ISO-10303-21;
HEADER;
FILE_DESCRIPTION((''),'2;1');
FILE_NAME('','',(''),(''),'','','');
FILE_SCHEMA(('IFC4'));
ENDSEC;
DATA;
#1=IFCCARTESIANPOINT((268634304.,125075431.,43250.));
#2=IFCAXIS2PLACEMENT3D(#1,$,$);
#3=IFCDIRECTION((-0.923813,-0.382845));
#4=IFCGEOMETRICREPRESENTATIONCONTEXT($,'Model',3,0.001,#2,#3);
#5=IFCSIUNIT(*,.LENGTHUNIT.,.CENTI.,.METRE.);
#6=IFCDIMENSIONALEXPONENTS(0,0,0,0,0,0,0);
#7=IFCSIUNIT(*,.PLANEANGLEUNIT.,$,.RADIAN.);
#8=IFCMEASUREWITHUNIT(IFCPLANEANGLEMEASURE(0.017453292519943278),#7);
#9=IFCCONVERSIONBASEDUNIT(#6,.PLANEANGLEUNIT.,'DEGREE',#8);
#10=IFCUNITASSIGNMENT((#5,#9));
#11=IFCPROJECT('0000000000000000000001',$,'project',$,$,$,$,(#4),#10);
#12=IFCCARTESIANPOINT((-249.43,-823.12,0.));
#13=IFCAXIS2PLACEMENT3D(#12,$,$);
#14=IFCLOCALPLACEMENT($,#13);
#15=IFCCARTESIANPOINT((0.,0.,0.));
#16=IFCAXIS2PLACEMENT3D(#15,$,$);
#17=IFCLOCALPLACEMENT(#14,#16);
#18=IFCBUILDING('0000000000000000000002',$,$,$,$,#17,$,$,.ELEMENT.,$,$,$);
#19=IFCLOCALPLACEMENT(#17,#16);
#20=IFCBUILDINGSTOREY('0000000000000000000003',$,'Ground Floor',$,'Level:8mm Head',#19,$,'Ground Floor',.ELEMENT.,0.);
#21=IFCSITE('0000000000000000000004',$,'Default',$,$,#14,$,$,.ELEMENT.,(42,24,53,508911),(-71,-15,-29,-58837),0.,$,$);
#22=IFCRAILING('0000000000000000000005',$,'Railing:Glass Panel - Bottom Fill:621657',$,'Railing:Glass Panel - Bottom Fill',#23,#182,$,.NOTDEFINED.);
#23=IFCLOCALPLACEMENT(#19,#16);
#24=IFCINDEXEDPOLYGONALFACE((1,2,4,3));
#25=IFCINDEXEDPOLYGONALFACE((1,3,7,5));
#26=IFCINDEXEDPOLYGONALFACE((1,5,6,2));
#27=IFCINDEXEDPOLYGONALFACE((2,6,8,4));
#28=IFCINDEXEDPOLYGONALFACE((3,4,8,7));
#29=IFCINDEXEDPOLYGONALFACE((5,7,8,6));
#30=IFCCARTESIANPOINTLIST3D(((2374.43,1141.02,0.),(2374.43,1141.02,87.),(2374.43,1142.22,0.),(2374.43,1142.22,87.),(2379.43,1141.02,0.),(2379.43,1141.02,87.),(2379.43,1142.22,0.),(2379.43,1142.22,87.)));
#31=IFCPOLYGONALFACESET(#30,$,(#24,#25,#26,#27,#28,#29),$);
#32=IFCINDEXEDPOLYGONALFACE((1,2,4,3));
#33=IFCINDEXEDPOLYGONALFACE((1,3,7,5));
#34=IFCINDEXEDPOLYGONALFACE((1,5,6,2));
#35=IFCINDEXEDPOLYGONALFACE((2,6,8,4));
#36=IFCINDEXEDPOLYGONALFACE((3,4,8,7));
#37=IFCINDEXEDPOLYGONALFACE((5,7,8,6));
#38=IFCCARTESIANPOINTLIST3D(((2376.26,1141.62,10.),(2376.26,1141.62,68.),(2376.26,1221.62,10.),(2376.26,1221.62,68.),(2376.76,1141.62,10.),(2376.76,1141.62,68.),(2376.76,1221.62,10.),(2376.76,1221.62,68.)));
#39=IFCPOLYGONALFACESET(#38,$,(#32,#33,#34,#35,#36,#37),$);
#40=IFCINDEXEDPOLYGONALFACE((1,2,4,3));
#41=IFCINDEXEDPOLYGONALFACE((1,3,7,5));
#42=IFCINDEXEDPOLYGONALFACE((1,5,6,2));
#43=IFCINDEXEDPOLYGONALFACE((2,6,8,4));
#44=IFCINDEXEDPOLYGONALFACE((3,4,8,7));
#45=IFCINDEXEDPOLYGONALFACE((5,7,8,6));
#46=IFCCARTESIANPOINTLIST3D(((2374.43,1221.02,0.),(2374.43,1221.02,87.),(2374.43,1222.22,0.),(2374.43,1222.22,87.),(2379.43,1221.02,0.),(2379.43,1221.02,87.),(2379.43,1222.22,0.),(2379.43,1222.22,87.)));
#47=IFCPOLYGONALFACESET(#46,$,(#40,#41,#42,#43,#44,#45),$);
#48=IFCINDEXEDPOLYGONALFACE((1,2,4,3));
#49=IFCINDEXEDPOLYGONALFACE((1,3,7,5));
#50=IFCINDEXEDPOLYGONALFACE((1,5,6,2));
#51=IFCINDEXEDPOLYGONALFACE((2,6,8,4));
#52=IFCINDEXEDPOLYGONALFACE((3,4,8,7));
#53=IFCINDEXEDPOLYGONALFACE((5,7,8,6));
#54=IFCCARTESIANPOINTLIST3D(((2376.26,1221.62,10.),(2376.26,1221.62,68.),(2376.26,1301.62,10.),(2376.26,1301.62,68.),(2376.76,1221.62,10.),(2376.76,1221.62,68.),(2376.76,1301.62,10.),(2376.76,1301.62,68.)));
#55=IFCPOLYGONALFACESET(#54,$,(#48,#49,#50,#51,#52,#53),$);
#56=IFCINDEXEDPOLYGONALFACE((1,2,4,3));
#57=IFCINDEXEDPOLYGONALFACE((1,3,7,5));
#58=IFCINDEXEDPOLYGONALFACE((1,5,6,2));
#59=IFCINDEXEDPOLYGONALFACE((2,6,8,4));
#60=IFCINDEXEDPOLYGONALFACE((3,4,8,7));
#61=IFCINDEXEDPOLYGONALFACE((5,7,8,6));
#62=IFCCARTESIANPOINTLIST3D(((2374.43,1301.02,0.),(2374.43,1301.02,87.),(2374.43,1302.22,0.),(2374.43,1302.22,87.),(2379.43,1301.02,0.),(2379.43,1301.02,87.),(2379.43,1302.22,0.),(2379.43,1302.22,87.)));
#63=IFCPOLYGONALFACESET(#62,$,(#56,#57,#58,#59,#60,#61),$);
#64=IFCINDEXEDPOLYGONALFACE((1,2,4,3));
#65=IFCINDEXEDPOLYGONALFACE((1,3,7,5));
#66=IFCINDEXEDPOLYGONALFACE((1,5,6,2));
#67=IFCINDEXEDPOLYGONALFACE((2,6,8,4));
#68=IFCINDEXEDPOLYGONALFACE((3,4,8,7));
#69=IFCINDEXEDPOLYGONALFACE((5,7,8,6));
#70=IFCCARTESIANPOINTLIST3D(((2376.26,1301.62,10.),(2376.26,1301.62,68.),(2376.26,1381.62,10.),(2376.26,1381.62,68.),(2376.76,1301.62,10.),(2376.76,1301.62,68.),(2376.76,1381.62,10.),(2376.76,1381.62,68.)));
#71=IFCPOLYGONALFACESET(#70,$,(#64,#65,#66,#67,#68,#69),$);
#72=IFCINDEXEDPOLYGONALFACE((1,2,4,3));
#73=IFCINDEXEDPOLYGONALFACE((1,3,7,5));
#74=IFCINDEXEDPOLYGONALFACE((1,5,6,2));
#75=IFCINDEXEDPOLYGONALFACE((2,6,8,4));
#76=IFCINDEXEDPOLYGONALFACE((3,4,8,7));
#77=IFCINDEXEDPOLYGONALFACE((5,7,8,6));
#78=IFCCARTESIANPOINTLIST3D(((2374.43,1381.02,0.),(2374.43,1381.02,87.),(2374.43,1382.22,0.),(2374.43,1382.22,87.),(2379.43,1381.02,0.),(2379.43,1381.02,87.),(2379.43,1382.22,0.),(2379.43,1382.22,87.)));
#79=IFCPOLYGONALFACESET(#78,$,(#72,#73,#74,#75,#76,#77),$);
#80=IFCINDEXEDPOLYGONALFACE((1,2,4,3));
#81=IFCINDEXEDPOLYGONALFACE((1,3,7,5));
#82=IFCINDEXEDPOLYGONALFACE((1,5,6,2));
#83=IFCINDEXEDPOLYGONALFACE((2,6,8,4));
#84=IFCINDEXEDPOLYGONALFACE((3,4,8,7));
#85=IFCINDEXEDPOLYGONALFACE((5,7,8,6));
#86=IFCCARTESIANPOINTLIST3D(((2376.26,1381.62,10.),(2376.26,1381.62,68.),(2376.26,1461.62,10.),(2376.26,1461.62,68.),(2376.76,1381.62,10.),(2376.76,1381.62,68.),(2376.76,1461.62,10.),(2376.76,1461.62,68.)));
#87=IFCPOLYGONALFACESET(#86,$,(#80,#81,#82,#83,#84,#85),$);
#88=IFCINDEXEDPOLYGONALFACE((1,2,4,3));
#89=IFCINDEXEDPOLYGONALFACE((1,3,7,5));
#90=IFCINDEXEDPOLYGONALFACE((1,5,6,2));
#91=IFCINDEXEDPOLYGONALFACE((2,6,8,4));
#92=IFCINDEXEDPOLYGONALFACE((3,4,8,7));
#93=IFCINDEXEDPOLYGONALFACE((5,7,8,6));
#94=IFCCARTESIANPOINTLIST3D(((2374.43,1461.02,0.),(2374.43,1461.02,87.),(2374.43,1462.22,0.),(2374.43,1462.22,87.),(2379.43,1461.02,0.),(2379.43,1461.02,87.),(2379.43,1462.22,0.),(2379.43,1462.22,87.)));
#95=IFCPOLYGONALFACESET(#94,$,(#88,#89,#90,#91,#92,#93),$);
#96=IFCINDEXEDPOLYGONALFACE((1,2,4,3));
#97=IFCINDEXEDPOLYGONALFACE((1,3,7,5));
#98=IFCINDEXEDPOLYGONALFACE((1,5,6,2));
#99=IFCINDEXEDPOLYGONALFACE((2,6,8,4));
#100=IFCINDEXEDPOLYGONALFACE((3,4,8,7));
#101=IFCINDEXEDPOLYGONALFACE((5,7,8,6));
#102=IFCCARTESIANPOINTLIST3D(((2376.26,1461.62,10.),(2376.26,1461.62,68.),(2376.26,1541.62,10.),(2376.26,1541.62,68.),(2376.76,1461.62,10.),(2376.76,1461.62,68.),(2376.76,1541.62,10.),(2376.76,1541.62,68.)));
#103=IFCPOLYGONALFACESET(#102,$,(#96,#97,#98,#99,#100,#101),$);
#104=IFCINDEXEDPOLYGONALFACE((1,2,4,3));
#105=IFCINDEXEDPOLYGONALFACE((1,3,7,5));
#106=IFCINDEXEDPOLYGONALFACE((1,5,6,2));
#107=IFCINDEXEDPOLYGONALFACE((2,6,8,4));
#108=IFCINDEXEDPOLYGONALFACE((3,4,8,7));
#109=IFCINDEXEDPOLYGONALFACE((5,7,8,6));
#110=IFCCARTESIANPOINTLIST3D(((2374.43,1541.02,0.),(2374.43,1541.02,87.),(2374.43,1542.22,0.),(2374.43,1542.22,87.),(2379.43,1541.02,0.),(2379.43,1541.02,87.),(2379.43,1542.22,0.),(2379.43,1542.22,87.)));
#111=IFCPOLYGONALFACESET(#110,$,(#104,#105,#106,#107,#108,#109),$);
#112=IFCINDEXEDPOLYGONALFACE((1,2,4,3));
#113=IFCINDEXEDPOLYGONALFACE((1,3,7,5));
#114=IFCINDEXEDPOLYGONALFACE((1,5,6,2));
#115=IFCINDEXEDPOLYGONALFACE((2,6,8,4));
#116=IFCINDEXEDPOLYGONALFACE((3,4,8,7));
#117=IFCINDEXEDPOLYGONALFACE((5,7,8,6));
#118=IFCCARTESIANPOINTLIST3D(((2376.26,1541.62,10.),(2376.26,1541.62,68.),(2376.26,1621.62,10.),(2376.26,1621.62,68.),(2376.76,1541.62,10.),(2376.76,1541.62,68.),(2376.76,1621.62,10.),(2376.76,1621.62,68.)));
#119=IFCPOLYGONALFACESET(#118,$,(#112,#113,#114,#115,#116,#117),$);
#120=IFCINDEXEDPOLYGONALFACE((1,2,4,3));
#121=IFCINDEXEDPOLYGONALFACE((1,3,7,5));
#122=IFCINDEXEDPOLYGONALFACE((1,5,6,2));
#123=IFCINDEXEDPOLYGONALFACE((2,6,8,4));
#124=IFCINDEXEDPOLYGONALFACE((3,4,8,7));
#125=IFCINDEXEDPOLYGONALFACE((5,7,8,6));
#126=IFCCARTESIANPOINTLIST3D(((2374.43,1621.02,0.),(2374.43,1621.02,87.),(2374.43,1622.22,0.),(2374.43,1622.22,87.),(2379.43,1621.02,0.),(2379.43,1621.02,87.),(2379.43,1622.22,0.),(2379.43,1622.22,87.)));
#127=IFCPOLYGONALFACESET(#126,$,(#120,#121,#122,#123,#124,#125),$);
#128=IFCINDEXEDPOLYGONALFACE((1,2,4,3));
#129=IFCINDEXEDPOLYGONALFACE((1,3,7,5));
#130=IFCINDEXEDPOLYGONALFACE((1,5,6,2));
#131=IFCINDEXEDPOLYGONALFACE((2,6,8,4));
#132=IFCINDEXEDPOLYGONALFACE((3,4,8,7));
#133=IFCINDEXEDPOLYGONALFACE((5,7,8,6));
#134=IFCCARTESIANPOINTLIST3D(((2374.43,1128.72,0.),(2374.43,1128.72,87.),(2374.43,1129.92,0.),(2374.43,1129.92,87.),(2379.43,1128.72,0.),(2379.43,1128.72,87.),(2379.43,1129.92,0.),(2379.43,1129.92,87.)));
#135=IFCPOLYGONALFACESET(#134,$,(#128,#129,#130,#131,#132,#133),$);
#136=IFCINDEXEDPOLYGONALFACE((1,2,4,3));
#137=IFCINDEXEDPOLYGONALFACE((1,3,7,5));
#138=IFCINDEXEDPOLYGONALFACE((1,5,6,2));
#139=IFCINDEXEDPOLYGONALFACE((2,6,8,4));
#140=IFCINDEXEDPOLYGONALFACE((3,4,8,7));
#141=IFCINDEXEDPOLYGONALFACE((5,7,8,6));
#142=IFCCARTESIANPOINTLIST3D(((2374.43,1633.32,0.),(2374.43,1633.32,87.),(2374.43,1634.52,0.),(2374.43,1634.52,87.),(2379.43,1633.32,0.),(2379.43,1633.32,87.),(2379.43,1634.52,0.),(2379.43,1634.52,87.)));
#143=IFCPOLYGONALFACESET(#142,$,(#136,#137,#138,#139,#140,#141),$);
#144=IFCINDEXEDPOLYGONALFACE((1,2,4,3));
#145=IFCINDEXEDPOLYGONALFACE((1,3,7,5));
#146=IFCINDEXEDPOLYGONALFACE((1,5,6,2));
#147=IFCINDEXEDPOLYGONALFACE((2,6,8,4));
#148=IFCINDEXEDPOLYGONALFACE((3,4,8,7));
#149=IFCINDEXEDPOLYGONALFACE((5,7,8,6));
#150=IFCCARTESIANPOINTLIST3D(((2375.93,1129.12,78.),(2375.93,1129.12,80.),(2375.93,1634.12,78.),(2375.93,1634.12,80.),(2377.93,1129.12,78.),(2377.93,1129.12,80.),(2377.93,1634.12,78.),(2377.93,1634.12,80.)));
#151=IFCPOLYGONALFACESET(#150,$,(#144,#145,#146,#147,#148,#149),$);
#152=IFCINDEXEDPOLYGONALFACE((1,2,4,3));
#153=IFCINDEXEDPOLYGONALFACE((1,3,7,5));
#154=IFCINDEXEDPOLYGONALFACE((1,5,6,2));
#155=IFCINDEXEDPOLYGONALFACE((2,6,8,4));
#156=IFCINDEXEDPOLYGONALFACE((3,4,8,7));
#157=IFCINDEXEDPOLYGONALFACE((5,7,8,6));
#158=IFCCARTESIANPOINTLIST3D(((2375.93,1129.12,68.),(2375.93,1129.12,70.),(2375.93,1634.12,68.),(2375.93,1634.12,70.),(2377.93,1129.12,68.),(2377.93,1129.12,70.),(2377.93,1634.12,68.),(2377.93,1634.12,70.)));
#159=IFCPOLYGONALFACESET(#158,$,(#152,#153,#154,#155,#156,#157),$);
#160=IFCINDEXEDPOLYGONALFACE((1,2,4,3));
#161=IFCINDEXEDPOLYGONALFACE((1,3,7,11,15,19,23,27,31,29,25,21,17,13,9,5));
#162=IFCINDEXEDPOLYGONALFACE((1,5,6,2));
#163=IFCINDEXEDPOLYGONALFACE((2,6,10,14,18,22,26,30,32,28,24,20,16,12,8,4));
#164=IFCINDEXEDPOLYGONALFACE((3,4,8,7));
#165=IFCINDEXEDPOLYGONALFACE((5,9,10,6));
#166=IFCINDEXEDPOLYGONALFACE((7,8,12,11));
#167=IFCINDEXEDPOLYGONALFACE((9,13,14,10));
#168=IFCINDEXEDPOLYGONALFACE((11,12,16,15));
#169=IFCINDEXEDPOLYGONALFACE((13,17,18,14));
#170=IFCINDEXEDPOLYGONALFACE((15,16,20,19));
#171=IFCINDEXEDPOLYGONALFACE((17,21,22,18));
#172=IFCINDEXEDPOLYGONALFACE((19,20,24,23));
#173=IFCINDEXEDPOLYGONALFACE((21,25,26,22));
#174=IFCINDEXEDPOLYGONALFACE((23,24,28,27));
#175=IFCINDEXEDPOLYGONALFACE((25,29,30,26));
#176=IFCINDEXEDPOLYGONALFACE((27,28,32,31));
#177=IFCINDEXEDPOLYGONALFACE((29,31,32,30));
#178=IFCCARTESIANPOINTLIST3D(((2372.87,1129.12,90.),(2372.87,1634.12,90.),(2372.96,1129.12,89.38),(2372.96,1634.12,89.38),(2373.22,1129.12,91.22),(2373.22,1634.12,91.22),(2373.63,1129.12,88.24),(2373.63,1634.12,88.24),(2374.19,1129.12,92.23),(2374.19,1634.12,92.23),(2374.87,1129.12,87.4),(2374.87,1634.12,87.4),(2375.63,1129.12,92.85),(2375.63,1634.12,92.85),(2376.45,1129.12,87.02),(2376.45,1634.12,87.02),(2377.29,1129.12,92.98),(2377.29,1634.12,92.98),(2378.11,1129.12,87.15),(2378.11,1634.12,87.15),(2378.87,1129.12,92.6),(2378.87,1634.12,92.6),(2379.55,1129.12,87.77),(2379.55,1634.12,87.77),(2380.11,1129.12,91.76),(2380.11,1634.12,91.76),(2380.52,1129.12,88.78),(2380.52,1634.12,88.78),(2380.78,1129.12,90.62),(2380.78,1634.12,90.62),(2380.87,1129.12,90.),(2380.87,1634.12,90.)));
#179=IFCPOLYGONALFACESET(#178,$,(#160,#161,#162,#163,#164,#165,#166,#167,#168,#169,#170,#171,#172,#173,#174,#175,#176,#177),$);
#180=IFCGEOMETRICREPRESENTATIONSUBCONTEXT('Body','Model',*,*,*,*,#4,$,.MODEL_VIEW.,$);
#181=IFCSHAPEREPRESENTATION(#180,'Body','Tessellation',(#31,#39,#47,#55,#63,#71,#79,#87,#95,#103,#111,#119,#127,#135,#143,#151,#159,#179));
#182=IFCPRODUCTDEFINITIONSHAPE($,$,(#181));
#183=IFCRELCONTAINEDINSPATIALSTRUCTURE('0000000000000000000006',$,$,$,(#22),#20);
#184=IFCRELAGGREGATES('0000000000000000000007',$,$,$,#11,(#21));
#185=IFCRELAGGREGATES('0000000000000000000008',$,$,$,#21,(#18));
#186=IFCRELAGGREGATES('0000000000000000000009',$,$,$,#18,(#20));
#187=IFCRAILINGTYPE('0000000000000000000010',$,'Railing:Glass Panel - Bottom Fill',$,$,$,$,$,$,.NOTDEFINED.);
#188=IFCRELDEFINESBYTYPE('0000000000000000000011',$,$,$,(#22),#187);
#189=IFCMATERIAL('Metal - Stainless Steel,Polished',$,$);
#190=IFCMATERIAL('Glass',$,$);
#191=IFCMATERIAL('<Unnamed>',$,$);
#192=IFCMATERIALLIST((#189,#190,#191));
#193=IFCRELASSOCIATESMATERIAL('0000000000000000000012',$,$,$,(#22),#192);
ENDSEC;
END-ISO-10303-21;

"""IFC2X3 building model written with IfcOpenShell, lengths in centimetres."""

from ifc_helpers import new_model, entity, si_unit, converted_unit, direction, frame, frame_2d, origin, place, context, subcontext, project, spatial, polyline, rectangle, outline, extrude, material, material_list, type_object, element, save


model = new_model("IFC2X3")

# Units and contexts
model_context = context("Model", 3, precision=0.001, world=frame((268634304.0, 125075431.0, 43250.0)), true_north=direction((-0.923813, -0.382845)))
body_context = subcontext(model_context, "Body", "Model", "MODEL_VIEW")
ifc_project = project(units=[si_unit("LENGTHUNIT", "METRE", prefix="CENTI"), converted_unit("PLANEANGLEUNIT", "DEGREE", entity("IfcPlaneAngleMeasure", 0.017453292519943278), si_unit("PLANEANGLEUNIT", "RADIAN"), dimensions=[0, 0, 0, 0, 0, 0, 0])], contexts=[model_context])

# Site, building, storey
site_placement = place(None, frame((-249.43, -823.12, 0.0)))
site = spatial("IfcSite", under=ifc_project, at=site_placement, Name="Default", CompositionType="ELEMENT", RefLatitude=(42, 24, 53, 508911), RefLongitude=(-71, -15, -29, -58837), RefElevation=0.0)
building_placement = place(site_placement, origin())
building = spatial("IfcBuilding", under=site, at=building_placement, CompositionType="ELEMENT")
storey_placement = place(building_placement, origin())
storey = spatial("IfcBuildingStorey", under=building, at=storey_placement, Name="Ground Floor", ObjectType="Level:8mm Head", LongName="Ground Floor", CompositionType="ELEMENT", Elevation=0.0)

# Shared definitions
ifc_material_1 = material(Name="Glass")

# Railing
ifc_material_2 = material(Name="Metal - Stainless Steel,Polished")
ifc_material_3 = material(Name="<Unnamed>")
ifc_material_list = material_list([ifc_material_2, ifc_material_1, ifc_material_3])
railing_type = type_object("IfcRailingType", Name="Railing:Glass Panel - Bottom Fill", PredefinedType="NOTDEFINED")
railing_1_placement = place(storey_placement, frame((2372.71, 1128.72, 0.0)))
element("IfcRailing", 1, at=railing_1_placement, inside=storey, type_object=railing_type, material=ifc_material_list, Name="Railing:Glass Panel - Bottom Fill:621657", ObjectType="Railing:Glass Panel - Bottom Fill", PredefinedType="NOTDEFINED", context=body_context, shape_type="SweptSolid", body=[
    extrude(rectangle(XDim=5.0, YDim=1.2, at=frame_2d((0.0, 0.0), x_axis=(1.0, 0.0))), frame((4.22, 12.9, 0.0), z_axis=(0.0, 0.0, 1.0), x_axis=(-1.0, 0.0, 0.0)), (0.0, 0.0, 1.0), 87.0),
    extrude(rectangle(XDim=0.5, YDim=80.0, at=frame_2d((0.0, 0.0), x_axis=(1.0, 0.0))), frame((3.8, 52.9, 10.0), z_axis=(0.0, 0.0, 1.0), x_axis=(-1.0, 0.0, 0.0)), (0.0, 0.0, 1.0), 58.0),
    extrude(rectangle(XDim=5.0, YDim=1.2, at=frame_2d((0.0, 0.0), x_axis=(1.0, 0.0))), frame((4.22, 92.9, 0.0), z_axis=(0.0, 0.0, 1.0), x_axis=(-1.0, 0.0, 0.0)), (0.0, 0.0, 1.0), 87.0),
    extrude(rectangle(XDim=0.5, YDim=80.0, at=frame_2d((0.0, 0.0), x_axis=(1.0, 0.0))), frame((3.8, 132.9, 10.0), z_axis=(0.0, 0.0, 1.0), x_axis=(-1.0, 0.0, 0.0)), (0.0, 0.0, 1.0), 58.0),
    extrude(rectangle(XDim=5.0, YDim=1.2, at=frame_2d((0.0, 0.0), x_axis=(1.0, 0.0))), frame((4.22, 172.9, 0.0), z_axis=(0.0, 0.0, 1.0), x_axis=(-1.0, 0.0, 0.0)), (0.0, 0.0, 1.0), 87.0),
    extrude(rectangle(XDim=0.5, YDim=80.0, at=frame_2d((0.0, 0.0), x_axis=(1.0, 0.0))), frame((3.8, 212.9, 10.0), z_axis=(0.0, 0.0, 1.0), x_axis=(-1.0, 0.0, 0.0)), (0.0, 0.0, 1.0), 58.0),
    extrude(rectangle(XDim=5.0, YDim=1.2, at=frame_2d((0.0, 0.0), x_axis=(1.0, 0.0))), frame((4.22, 252.9, 0.0), z_axis=(0.0, 0.0, 1.0), x_axis=(-1.0, 0.0, 0.0)), (0.0, 0.0, 1.0), 87.0),
    extrude(rectangle(XDim=0.5, YDim=80.0, at=frame_2d((0.0, 0.0), x_axis=(1.0, 0.0))), frame((3.8, 292.9, 10.0), z_axis=(0.0, 0.0, 1.0), x_axis=(-1.0, 0.0, 0.0)), (0.0, 0.0, 1.0), 58.0),
    extrude(rectangle(XDim=5.0, YDim=1.2, at=frame_2d((0.0, 0.0), x_axis=(1.0, 0.0))), frame((4.22, 332.9, 0.0), z_axis=(0.0, 0.0, 1.0), x_axis=(-1.0, 0.0, 0.0)), (0.0, 0.0, 1.0), 87.0),
    extrude(rectangle(XDim=0.5, YDim=80.0, at=frame_2d((0.0, 0.0), x_axis=(1.0, 0.0))), frame((3.8, 372.9, 10.0), z_axis=(0.0, 0.0, 1.0), x_axis=(-1.0, 0.0, 0.0)), (0.0, 0.0, 1.0), 58.0),
    extrude(rectangle(XDim=5.0, YDim=1.2, at=frame_2d((0.0, 0.0), x_axis=(1.0, 0.0))), frame((4.22, 412.9, 0.0), z_axis=(0.0, 0.0, 1.0), x_axis=(-1.0, 0.0, 0.0)), (0.0, 0.0, 1.0), 87.0),
    extrude(rectangle(XDim=0.5, YDim=80.0, at=frame_2d((0.0, 0.0), x_axis=(1.0, 0.0))), frame((3.8, 452.9, 10.0), z_axis=(0.0, 0.0, 1.0), x_axis=(-1.0, 0.0, 0.0)), (0.0, 0.0, 1.0), 58.0),
    extrude(rectangle(XDim=5.0, YDim=1.2, at=frame_2d((0.0, 0.0), x_axis=(1.0, 0.0))), frame((4.22, 492.9, 0.0), z_axis=(0.0, 0.0, 1.0), x_axis=(-1.0, 0.0, 0.0)), (0.0, 0.0, 1.0), 87.0),
    extrude(rectangle(XDim=5.0, YDim=1.2, at=frame_2d((0.0, 0.0), x_axis=(1.0, 0.0))), frame((4.22, 0.6, 0.0), z_axis=(0.0, 0.0, 1.0), x_axis=(-1.0, 0.0, 0.0)), (0.0, 0.0, 1.0), 87.0),
    extrude(rectangle(XDim=5.0, YDim=1.2, at=frame_2d((0.0, 0.0), x_axis=(1.0, 0.0))), frame((4.22, 505.2, 0.0), z_axis=(0.0, 0.0, 1.0), x_axis=(-1.0, 0.0, 0.0)), (0.0, 0.0, 1.0), 87.0),
    extrude(rectangle(XDim=505.0, YDim=2.0, at=frame_2d((0.0, 0.0), x_axis=(1.0, 0.0))), frame((4.22, 252.9, 78.0), z_axis=(0.0, 0.0, 1.0), x_axis=(0.0, -1.0, 0.0)), (0.0, 0.0, 1.0), 2.0),
    extrude(rectangle(XDim=505.0, YDim=2.0, at=frame_2d((0.0, 0.0), x_axis=(1.0, 0.0))), frame((4.22, 252.9, 68.0), z_axis=(0.0, 0.0, 1.0), x_axis=(0.0, -1.0, 0.0)), (0.0, 0.0, 1.0), 2.0),
    extrude(outline(polyline([(-1.09, -3.85), (0.18, -3.85), (1.42, -3.18), (2.41, -1.97), (2.98, -0.41), (3.04, 1.22), (2.58, 2.63), (1.67, 3.59), (1.09, 3.85), (-0.18, 3.85), (-1.42, 3.18), (-2.41, 1.97), (-2.98, 0.41), (-3.04, -1.22), (-2.58, -2.63), (-1.67, -3.59), (-1.09, -3.85)])), frame((4.16, 0.4, 90.0), z_axis=(0.0, 1.0, 0.0), x_axis=(-0.27267, 0.0, -0.962108)), (0.0, 0.0, 1.0), 505.0),
])

save(model, "model.ifc")
